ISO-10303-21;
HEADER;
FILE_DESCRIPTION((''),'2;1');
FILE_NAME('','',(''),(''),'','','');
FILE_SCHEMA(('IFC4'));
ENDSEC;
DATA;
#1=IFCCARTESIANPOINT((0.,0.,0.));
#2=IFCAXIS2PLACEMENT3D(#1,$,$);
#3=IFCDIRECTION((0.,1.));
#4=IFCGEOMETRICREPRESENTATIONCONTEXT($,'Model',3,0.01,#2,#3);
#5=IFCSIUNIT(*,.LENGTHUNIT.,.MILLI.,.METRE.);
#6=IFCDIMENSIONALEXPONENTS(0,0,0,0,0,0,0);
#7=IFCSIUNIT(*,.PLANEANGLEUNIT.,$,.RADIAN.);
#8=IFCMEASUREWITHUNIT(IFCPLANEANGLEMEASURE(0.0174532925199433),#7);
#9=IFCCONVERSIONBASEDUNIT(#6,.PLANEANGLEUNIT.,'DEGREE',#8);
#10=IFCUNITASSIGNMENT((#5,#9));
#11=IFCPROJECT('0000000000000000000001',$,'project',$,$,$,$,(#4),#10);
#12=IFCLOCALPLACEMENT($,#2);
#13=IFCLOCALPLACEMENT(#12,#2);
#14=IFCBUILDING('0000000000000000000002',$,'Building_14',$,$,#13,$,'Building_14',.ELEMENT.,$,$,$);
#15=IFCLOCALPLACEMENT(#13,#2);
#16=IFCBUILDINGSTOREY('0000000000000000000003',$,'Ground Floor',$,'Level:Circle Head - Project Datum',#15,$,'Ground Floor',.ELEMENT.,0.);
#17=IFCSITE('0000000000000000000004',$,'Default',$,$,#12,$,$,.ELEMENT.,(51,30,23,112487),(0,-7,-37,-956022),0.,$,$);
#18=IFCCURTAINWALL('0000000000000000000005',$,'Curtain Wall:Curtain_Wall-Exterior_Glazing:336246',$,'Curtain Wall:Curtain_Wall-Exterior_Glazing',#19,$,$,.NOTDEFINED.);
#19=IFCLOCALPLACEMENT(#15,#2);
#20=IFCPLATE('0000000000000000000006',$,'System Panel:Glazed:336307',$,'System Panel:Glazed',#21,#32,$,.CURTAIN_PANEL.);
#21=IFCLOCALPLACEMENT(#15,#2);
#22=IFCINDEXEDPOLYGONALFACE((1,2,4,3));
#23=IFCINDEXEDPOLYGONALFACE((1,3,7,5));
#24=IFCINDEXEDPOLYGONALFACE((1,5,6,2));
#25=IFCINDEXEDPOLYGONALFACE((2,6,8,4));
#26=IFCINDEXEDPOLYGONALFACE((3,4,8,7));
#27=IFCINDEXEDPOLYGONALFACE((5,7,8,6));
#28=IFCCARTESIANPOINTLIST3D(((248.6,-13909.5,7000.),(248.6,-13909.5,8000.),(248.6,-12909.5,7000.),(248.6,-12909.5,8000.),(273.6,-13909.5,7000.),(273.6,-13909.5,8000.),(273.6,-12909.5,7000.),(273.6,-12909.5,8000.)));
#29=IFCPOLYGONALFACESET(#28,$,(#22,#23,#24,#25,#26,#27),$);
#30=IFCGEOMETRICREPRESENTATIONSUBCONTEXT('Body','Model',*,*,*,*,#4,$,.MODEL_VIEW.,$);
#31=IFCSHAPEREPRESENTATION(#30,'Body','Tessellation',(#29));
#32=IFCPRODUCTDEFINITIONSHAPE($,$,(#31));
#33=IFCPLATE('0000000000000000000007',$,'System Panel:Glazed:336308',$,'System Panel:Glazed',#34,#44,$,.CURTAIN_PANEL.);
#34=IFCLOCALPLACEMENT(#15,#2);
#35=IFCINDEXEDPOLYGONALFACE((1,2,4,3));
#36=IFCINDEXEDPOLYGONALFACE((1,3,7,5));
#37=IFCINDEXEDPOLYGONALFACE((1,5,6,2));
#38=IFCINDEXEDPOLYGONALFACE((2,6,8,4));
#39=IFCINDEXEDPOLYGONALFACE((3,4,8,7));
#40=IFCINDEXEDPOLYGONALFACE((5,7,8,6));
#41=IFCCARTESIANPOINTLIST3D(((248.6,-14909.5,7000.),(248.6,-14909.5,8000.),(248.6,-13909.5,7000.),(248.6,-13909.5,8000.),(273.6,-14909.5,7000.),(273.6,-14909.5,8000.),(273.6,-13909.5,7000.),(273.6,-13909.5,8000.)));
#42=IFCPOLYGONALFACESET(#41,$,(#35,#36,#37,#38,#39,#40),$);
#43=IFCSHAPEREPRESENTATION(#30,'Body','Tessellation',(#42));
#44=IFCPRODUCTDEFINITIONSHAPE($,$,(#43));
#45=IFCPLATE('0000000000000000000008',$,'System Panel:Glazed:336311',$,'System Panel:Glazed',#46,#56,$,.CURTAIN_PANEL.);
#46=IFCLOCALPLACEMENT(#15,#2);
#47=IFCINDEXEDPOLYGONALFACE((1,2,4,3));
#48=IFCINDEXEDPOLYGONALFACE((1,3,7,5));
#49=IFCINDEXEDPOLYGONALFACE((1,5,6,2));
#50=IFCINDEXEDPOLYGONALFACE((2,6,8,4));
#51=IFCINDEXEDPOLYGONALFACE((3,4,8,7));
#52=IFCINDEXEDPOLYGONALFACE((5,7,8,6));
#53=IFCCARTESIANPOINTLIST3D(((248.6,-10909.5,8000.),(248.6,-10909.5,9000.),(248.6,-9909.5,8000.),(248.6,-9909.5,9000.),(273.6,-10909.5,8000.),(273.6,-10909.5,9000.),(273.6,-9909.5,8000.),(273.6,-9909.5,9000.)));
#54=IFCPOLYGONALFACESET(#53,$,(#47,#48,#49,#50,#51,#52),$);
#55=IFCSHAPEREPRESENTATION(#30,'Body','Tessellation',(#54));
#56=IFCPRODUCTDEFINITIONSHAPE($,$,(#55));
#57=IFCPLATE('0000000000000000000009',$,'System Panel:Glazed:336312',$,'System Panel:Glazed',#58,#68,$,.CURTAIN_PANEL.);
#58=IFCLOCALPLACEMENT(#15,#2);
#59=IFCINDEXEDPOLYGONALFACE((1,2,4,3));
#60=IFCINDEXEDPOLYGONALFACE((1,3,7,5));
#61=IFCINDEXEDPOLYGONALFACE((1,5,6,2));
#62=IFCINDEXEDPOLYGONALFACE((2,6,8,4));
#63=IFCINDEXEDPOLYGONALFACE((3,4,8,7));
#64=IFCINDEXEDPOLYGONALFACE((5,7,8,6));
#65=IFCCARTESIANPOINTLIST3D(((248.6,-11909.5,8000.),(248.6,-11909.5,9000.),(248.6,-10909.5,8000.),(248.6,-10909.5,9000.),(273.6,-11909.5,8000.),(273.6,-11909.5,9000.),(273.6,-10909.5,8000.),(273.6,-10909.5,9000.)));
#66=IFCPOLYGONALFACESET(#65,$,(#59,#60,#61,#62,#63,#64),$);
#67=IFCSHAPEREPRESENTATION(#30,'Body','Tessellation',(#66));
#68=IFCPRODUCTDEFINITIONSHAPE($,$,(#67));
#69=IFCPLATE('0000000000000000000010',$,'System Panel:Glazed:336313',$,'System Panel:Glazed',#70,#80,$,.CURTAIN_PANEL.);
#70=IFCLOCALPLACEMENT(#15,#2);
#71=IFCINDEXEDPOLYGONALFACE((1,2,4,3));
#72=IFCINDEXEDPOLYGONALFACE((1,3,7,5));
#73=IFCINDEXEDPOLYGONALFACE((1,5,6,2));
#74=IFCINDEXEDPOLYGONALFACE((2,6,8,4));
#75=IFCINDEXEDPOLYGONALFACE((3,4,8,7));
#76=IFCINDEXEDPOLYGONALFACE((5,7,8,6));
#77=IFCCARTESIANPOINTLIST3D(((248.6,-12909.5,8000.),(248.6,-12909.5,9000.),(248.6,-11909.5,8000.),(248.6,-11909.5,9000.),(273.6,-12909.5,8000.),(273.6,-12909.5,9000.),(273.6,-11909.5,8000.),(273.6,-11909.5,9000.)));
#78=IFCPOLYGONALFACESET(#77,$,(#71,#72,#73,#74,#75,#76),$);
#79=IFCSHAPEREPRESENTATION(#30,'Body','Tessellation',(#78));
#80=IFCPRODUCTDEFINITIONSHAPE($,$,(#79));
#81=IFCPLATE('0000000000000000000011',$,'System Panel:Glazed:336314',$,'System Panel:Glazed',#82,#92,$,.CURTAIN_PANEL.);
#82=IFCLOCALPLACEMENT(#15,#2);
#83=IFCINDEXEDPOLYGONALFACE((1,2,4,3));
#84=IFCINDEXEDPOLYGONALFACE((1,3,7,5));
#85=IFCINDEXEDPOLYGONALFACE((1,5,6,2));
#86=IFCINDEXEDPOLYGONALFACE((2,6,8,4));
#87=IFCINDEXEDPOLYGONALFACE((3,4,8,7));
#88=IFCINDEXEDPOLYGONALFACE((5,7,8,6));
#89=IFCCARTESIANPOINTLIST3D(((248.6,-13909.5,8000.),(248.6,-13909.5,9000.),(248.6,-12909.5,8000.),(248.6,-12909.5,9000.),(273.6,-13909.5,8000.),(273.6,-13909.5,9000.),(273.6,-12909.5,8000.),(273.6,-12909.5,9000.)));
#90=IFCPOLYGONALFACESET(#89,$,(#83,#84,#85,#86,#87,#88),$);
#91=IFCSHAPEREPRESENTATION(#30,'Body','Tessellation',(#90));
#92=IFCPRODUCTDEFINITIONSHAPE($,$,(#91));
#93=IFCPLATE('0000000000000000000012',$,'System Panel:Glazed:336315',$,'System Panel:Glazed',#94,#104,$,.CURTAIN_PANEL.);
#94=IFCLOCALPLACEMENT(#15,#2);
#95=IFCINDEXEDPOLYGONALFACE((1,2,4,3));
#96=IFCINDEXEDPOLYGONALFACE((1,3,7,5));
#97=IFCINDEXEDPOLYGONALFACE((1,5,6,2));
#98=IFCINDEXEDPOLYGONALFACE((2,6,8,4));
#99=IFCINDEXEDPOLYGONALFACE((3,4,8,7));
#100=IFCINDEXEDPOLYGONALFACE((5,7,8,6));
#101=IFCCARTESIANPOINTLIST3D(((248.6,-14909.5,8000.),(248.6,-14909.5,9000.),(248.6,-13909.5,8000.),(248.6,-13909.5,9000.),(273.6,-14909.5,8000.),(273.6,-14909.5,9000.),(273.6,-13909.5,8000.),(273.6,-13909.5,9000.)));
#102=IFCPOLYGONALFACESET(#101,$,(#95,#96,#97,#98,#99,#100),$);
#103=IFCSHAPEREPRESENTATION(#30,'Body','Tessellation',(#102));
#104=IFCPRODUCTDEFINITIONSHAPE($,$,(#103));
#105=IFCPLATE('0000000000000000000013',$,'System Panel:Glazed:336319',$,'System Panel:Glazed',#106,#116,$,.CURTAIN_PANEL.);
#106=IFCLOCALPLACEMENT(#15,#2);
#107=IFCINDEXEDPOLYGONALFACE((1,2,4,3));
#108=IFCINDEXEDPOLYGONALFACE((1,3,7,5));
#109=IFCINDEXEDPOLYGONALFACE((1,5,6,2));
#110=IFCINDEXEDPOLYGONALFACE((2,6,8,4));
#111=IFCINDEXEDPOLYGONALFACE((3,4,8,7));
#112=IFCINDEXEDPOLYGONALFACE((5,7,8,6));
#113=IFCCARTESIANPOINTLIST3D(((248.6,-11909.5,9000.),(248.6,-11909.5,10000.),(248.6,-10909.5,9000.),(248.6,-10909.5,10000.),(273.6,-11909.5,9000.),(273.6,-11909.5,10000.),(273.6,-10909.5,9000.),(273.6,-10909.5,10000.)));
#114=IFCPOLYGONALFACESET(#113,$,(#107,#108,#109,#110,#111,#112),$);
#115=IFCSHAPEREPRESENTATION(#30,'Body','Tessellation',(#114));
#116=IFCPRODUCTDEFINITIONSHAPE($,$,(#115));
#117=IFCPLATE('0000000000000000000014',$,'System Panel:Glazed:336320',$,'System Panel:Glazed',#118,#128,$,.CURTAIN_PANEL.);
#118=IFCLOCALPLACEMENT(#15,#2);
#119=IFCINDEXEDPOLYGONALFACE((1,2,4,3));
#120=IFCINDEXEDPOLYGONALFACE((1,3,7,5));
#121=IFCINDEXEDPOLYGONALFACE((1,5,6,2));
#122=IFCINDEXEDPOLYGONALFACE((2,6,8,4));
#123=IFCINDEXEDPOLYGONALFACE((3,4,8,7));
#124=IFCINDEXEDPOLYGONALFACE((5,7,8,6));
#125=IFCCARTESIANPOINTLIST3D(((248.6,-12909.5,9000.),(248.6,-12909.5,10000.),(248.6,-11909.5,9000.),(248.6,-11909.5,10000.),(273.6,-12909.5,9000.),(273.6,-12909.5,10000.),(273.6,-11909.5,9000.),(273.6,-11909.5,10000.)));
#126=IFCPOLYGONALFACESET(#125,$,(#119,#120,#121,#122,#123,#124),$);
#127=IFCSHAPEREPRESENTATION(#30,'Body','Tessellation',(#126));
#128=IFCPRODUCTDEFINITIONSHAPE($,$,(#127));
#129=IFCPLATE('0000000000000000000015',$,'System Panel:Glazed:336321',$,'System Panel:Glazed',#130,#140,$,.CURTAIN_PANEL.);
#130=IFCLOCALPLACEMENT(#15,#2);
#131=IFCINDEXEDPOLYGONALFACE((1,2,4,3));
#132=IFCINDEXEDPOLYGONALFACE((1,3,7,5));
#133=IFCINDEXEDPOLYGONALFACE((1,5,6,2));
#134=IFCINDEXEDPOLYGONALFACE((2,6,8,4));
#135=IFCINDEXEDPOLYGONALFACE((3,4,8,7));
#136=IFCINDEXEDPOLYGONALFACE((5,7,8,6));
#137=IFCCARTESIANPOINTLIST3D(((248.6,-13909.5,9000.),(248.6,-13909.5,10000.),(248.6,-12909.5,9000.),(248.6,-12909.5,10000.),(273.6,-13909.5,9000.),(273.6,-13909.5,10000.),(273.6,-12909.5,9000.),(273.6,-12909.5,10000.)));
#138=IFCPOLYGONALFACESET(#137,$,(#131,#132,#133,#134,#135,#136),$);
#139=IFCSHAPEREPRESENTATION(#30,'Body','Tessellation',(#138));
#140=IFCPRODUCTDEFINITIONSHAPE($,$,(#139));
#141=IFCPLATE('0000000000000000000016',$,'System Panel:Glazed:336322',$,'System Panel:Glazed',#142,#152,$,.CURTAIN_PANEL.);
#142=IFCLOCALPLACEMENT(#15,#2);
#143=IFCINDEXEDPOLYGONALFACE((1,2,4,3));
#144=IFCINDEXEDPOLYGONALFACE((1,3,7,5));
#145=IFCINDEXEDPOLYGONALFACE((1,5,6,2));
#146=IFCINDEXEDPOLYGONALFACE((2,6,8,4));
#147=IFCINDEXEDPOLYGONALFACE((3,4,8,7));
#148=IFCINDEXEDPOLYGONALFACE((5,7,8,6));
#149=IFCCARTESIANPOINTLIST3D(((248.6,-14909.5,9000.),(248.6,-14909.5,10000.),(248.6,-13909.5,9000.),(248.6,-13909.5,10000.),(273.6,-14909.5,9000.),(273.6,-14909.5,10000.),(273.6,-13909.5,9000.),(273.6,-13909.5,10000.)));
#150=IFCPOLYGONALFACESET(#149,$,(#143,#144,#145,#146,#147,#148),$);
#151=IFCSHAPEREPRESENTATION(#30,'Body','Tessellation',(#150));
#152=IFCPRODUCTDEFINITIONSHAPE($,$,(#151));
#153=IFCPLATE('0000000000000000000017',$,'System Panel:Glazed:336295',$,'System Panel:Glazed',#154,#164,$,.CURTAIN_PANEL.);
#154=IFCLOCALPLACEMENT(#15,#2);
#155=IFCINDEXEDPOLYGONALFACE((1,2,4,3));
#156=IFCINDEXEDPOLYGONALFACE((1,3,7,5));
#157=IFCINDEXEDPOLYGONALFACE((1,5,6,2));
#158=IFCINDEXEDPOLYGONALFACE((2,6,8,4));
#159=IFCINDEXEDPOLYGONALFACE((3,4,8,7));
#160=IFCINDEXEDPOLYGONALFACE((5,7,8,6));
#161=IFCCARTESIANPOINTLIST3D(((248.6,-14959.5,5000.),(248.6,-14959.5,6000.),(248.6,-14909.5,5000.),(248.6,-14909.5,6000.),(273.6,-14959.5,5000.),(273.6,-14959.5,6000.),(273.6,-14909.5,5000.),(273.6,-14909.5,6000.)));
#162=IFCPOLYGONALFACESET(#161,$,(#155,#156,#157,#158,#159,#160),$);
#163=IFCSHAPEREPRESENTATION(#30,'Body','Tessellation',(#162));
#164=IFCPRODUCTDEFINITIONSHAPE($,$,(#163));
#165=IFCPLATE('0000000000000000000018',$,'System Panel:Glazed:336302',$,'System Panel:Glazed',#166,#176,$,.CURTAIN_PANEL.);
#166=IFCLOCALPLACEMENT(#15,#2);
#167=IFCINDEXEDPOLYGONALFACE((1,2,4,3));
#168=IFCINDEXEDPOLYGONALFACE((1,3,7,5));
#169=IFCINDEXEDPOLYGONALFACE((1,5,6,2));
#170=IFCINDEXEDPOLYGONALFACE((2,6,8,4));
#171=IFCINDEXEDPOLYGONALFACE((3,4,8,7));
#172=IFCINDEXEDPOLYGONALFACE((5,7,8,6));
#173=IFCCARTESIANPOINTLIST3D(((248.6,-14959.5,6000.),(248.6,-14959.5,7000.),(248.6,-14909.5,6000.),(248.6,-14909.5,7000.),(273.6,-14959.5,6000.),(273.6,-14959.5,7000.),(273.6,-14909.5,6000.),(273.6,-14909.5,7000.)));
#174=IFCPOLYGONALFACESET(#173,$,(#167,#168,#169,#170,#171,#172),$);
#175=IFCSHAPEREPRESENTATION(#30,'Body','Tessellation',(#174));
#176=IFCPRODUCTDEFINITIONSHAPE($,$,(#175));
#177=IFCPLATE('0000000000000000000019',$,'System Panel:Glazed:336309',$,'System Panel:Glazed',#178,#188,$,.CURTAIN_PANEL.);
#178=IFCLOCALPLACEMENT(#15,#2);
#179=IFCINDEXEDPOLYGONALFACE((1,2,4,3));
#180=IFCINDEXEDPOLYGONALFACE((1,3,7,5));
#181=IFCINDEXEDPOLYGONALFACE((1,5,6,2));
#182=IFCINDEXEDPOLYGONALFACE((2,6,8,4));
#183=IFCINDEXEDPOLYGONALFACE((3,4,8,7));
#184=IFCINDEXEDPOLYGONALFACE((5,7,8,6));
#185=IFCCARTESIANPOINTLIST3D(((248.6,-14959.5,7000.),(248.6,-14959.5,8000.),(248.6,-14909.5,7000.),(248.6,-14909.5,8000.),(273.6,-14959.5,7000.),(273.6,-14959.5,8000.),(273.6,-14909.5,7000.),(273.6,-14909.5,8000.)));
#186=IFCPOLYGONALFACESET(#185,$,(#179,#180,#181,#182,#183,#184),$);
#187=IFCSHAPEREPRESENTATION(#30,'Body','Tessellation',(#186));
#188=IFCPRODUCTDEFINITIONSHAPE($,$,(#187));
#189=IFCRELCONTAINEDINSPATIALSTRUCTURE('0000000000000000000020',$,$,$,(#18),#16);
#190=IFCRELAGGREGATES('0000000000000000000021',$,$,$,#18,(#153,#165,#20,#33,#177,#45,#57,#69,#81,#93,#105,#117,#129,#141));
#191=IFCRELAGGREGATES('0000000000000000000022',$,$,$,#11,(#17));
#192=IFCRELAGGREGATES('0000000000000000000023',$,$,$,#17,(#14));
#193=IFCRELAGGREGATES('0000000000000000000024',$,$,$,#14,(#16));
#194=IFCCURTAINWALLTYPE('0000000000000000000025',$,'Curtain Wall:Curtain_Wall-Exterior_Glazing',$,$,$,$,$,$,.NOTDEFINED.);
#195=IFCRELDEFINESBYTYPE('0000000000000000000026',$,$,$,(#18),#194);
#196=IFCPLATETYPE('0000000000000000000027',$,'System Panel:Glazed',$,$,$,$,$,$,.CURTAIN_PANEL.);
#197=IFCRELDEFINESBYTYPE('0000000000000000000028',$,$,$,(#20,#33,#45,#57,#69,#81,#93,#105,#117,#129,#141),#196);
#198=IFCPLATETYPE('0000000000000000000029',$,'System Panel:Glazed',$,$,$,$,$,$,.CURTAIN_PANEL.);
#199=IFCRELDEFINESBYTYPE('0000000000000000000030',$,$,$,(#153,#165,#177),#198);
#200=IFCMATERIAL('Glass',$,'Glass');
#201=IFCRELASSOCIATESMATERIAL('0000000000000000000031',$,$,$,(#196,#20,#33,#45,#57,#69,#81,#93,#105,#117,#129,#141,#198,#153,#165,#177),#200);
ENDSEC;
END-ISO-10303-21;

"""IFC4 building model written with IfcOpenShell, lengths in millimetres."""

from ifc_helpers import new_model, entity, si_unit, converted_unit, direction, frame, origin, place, context, subcontext, project, spatial, indexed_curve, outline, extrude, source, transform, mapped, material, type_object, type_shapes, element, aggregate, save


model = new_model("IFC4")

# Units and contexts
model_context = context("Model", 3, precision=0.01, world=origin(), true_north=direction((0.0, 1.0)))
body_context = subcontext(model_context, "Body", "Model", "MODEL_VIEW")
ifc_project = project(units=[si_unit("LENGTHUNIT", "METRE", prefix="MILLI"), converted_unit("PLANEANGLEUNIT", "DEGREE", entity("IfcPlaneAngleMeasure", 0.0174532925199433), si_unit("PLANEANGLEUNIT", "RADIAN"), dimensions=[0, 0, 0, 0, 0, 0, 0])], contexts=[model_context])

# Site, building, storey
site_placement = place(None, origin())
site = spatial("IfcSite", under=ifc_project, at=site_placement, Name="Default", CompositionType="ELEMENT", RefLatitude=(51, 30, 23, 112487), RefLongitude=(0, -7, -37, -956022), RefElevation=0.0)
building_placement = place(site_placement, origin())
building = spatial("IfcBuilding", under=site, at=building_placement, Name="Building_14", LongName="Building_14", CompositionType="ELEMENT")
storey_placement = place(building_placement, origin())
storey = spatial("IfcBuildingStorey", under=building, at=storey_placement, Name="Ground Floor", ObjectType="Level:Circle Head - Project Datum", LongName="Ground Floor", CompositionType="ELEMENT", Elevation=0.0)

# Curtain wall, plates
curtain_wall_type = type_object("IfcCurtainWallType", Name="Curtain Wall:Curtain_Wall-Exterior_Glazing", PredefinedType="NOTDEFINED")
curtain_wall_1_placement = place(storey_placement, origin())
curtain_wall_1 = element("IfcCurtainWall", 1, at=curtain_wall_1_placement, inside=storey, type_object=curtain_wall_type, Name="Curtain Wall:Curtain_Wall-Exterior_Glazing:336246", ObjectType="Curtain Wall:Curtain_Wall-Exterior_Glazing", PredefinedType="NOTDEFINED")
ifc_material = material(Name="Glass", Category="Glass")
plate_type_1 = type_object("IfcPlateType", Name="System Panel:Glazed", PredefinedType="CURTAIN_PANEL", material=ifc_material)
shared_shape_1 = source(origin(), body_context, "Body", "SweptSolid", [
    extrude(outline(indexed_curve([(-12.5, -500.0), (12.5, -500.0), (12.5, 500.0), (-12.5, 500.0), (-12.5, -500.0)], self_intersect=False)), frame((0.0, -37.0, 0.0), z_axis=(0.0, 0.0, 1.0), x_axis=(0.0, 1.0, 0.0)), (0.0, 0.0, 1.0), 1000.0),
])
type_shapes(plate_type_1, [shared_shape_1])
plate_1_placement = place(curtain_wall_1_placement, frame((298.1, -13409.5, 7000.0), z_axis=(0.0, 0.0, 1.0), x_axis=(0.0, -1.0, 0.0)))
plate_1 = element("IfcPlate", 2, at=plate_1_placement, type_object=plate_type_1, material=ifc_material, Name="System Panel:Glazed:336307", ObjectType="System Panel:Glazed", PredefinedType="CURTAIN_PANEL", context=body_context, shape_type="MappedRepresentation", body=[
    mapped(shared_shape_1, transform((0.0, 0.0, 0.0), scale=1.0)),
])
plate_2_placement = place(curtain_wall_1_placement, frame((298.1, -14409.5, 7000.0), z_axis=(0.0, 0.0, 1.0), x_axis=(0.0, -1.0, 0.0)))
plate_2 = element("IfcPlate", 3, at=plate_2_placement, type_object=plate_type_1, material=ifc_material, Name="System Panel:Glazed:336308", ObjectType="System Panel:Glazed", PredefinedType="CURTAIN_PANEL", context=body_context, shape_type="MappedRepresentation", body=[
    mapped(shared_shape_1, transform((0.0, 0.0, 0.0), scale=1.0)),
])
plate_3_placement = place(curtain_wall_1_placement, frame((298.1, -10409.5, 8000.0), z_axis=(0.0, 0.0, 1.0), x_axis=(0.0, -1.0, 0.0)))
plate_3 = element("IfcPlate", 4, at=plate_3_placement, type_object=plate_type_1, material=ifc_material, Name="System Panel:Glazed:336311", ObjectType="System Panel:Glazed", PredefinedType="CURTAIN_PANEL", context=body_context, shape_type="MappedRepresentation", body=[
    mapped(shared_shape_1, transform((0.0, 0.0, 0.0), scale=1.0)),
])
plate_4_placement = place(curtain_wall_1_placement, frame((298.1, -11409.5, 8000.0), z_axis=(0.0, 0.0, 1.0), x_axis=(0.0, -1.0, 0.0)))
plate_4 = element("IfcPlate", 5, at=plate_4_placement, type_object=plate_type_1, material=ifc_material, Name="System Panel:Glazed:336312", ObjectType="System Panel:Glazed", PredefinedType="CURTAIN_PANEL", context=body_context, shape_type="MappedRepresentation", body=[
    mapped(shared_shape_1, transform((0.0, 0.0, 0.0), scale=1.0)),
])
plate_5_placement = place(curtain_wall_1_placement, frame((298.1, -12409.5, 8000.0), z_axis=(0.0, 0.0, 1.0), x_axis=(0.0, -1.0, 0.0)))
plate_5 = element("IfcPlate", 6, at=plate_5_placement, type_object=plate_type_1, material=ifc_material, Name="System Panel:Glazed:336313", ObjectType="System Panel:Glazed", PredefinedType="CURTAIN_PANEL", context=body_context, shape_type="MappedRepresentation", body=[
    mapped(shared_shape_1, transform((0.0, 0.0, 0.0), scale=1.0)),
])
plate_6_placement = place(curtain_wall_1_placement, frame((298.1, -13409.5, 8000.0), z_axis=(0.0, 0.0, 1.0), x_axis=(0.0, -1.0, 0.0)))
plate_6 = element("IfcPlate", 7, at=plate_6_placement, type_object=plate_type_1, material=ifc_material, Name="System Panel:Glazed:336314", ObjectType="System Panel:Glazed", PredefinedType="CURTAIN_PANEL", context=body_context, shape_type="MappedRepresentation", body=[
    mapped(shared_shape_1, transform((0.0, 0.0, 0.0), scale=1.0)),
])
plate_7_placement = place(curtain_wall_1_placement, frame((298.1, -14409.5, 8000.0), z_axis=(0.0, 0.0, 1.0), x_axis=(0.0, -1.0, 0.0)))
plate_7 = element("IfcPlate", 8, at=plate_7_placement, type_object=plate_type_1, material=ifc_material, Name="System Panel:Glazed:336315", ObjectType="System Panel:Glazed", PredefinedType="CURTAIN_PANEL", context=body_context, shape_type="MappedRepresentation", body=[
    mapped(shared_shape_1, transform((0.0, 0.0, 0.0), scale=1.0)),
])
plate_8_placement = place(curtain_wall_1_placement, frame((298.1, -11409.5, 9000.0), z_axis=(0.0, 0.0, 1.0), x_axis=(0.0, -1.0, 0.0)))
plate_8 = element("IfcPlate", 9, at=plate_8_placement, type_object=plate_type_1, material=ifc_material, Name="System Panel:Glazed:336319", ObjectType="System Panel:Glazed", PredefinedType="CURTAIN_PANEL", context=body_context, shape_type="MappedRepresentation", body=[
    mapped(shared_shape_1, transform((0.0, 0.0, 0.0), scale=1.0)),
])
plate_9_placement = place(curtain_wall_1_placement, frame((298.1, -12409.5, 9000.0), z_axis=(0.0, 0.0, 1.0), x_axis=(0.0, -1.0, 0.0)))
plate_9 = element("IfcPlate", 10, at=plate_9_placement, type_object=plate_type_1, material=ifc_material, Name="System Panel:Glazed:336320", ObjectType="System Panel:Glazed", PredefinedType="CURTAIN_PANEL", context=body_context, shape_type="MappedRepresentation", body=[
    mapped(shared_shape_1, transform((0.0, 0.0, 0.0), scale=1.0)),
])
plate_10_placement = place(curtain_wall_1_placement, frame((298.1, -13409.5, 9000.0), z_axis=(0.0, 0.0, 1.0), x_axis=(0.0, -1.0, 0.0)))
plate_10 = element("IfcPlate", 11, at=plate_10_placement, type_object=plate_type_1, material=ifc_material, Name="System Panel:Glazed:336321", ObjectType="System Panel:Glazed", PredefinedType="CURTAIN_PANEL", context=body_context, shape_type="MappedRepresentation", body=[
    mapped(shared_shape_1, transform((0.0, 0.0, 0.0), scale=1.0)),
])
plate_11_placement = place(curtain_wall_1_placement, frame((298.1, -14409.5, 9000.0), z_axis=(0.0, 0.0, 1.0), x_axis=(0.0, -1.0, 0.0)))
plate_11 = element("IfcPlate", 12, at=plate_11_placement, type_object=plate_type_1, material=ifc_material, Name="System Panel:Glazed:336322", ObjectType="System Panel:Glazed", PredefinedType="CURTAIN_PANEL", context=body_context, shape_type="MappedRepresentation", body=[
    mapped(shared_shape_1, transform((0.0, 0.0, 0.0), scale=1.0)),
])
plate_type_2 = type_object("IfcPlateType", Name="System Panel:Glazed", PredefinedType="CURTAIN_PANEL", material=ifc_material)
shared_shape_2 = source(origin(), body_context, "Body", "SweptSolid", [
    extrude(outline(indexed_curve([(-12.5, -25.0), (12.5, -25.0), (12.5, 25.0), (-12.5, 25.0), (-12.5, -25.0)], self_intersect=False)), frame((0.0, -37.0, 0.0), z_axis=(0.0, 0.0, 1.0), x_axis=(0.0, 1.0, 0.0)), (0.0, 0.0, 1.0), 1000.0),
])
type_shapes(plate_type_2, [shared_shape_2])
plate_12_placement = place(curtain_wall_1_placement, frame((298.1, -14934.5, 5000.0), z_axis=(0.0, 0.0, 1.0), x_axis=(0.0, -1.0, 0.0)))
plate_12 = element("IfcPlate", 13, at=plate_12_placement, type_object=plate_type_2, material=ifc_material, Name="System Panel:Glazed:336295", ObjectType="System Panel:Glazed", PredefinedType="CURTAIN_PANEL", context=body_context, shape_type="MappedRepresentation", body=[
    mapped(shared_shape_2, transform((0.0, 0.0, 0.0), scale=1.0)),
])
plate_13_placement = place(curtain_wall_1_placement, frame((298.1, -14934.5, 6000.0), z_axis=(0.0, 0.0, 1.0), x_axis=(0.0, -1.0, 0.0)))
plate_13 = element("IfcPlate", 14, at=plate_13_placement, type_object=plate_type_2, material=ifc_material, Name="System Panel:Glazed:336302", ObjectType="System Panel:Glazed", PredefinedType="CURTAIN_PANEL", context=body_context, shape_type="MappedRepresentation", body=[
    mapped(shared_shape_2, transform((0.0, 0.0, 0.0), scale=1.0)),
])
plate_14_placement = place(curtain_wall_1_placement, frame((298.1, -14934.5, 7000.0), z_axis=(0.0, 0.0, 1.0), x_axis=(0.0, -1.0, 0.0)))
plate_14 = element("IfcPlate", 15, at=plate_14_placement, type_object=plate_type_2, material=ifc_material, Name="System Panel:Glazed:336309", ObjectType="System Panel:Glazed", PredefinedType="CURTAIN_PANEL", context=body_context, shape_type="MappedRepresentation", body=[
    mapped(shared_shape_2, transform((0.0, 0.0, 0.0), scale=1.0)),
])
aggregate(curtain_wall_1, [plate_12, plate_13, plate_1, plate_2, plate_14, plate_3, plate_4, plate_5, plate_6, plate_7, plate_8, plate_9, plate_10, plate_11])

save(model, "model.ifc")
